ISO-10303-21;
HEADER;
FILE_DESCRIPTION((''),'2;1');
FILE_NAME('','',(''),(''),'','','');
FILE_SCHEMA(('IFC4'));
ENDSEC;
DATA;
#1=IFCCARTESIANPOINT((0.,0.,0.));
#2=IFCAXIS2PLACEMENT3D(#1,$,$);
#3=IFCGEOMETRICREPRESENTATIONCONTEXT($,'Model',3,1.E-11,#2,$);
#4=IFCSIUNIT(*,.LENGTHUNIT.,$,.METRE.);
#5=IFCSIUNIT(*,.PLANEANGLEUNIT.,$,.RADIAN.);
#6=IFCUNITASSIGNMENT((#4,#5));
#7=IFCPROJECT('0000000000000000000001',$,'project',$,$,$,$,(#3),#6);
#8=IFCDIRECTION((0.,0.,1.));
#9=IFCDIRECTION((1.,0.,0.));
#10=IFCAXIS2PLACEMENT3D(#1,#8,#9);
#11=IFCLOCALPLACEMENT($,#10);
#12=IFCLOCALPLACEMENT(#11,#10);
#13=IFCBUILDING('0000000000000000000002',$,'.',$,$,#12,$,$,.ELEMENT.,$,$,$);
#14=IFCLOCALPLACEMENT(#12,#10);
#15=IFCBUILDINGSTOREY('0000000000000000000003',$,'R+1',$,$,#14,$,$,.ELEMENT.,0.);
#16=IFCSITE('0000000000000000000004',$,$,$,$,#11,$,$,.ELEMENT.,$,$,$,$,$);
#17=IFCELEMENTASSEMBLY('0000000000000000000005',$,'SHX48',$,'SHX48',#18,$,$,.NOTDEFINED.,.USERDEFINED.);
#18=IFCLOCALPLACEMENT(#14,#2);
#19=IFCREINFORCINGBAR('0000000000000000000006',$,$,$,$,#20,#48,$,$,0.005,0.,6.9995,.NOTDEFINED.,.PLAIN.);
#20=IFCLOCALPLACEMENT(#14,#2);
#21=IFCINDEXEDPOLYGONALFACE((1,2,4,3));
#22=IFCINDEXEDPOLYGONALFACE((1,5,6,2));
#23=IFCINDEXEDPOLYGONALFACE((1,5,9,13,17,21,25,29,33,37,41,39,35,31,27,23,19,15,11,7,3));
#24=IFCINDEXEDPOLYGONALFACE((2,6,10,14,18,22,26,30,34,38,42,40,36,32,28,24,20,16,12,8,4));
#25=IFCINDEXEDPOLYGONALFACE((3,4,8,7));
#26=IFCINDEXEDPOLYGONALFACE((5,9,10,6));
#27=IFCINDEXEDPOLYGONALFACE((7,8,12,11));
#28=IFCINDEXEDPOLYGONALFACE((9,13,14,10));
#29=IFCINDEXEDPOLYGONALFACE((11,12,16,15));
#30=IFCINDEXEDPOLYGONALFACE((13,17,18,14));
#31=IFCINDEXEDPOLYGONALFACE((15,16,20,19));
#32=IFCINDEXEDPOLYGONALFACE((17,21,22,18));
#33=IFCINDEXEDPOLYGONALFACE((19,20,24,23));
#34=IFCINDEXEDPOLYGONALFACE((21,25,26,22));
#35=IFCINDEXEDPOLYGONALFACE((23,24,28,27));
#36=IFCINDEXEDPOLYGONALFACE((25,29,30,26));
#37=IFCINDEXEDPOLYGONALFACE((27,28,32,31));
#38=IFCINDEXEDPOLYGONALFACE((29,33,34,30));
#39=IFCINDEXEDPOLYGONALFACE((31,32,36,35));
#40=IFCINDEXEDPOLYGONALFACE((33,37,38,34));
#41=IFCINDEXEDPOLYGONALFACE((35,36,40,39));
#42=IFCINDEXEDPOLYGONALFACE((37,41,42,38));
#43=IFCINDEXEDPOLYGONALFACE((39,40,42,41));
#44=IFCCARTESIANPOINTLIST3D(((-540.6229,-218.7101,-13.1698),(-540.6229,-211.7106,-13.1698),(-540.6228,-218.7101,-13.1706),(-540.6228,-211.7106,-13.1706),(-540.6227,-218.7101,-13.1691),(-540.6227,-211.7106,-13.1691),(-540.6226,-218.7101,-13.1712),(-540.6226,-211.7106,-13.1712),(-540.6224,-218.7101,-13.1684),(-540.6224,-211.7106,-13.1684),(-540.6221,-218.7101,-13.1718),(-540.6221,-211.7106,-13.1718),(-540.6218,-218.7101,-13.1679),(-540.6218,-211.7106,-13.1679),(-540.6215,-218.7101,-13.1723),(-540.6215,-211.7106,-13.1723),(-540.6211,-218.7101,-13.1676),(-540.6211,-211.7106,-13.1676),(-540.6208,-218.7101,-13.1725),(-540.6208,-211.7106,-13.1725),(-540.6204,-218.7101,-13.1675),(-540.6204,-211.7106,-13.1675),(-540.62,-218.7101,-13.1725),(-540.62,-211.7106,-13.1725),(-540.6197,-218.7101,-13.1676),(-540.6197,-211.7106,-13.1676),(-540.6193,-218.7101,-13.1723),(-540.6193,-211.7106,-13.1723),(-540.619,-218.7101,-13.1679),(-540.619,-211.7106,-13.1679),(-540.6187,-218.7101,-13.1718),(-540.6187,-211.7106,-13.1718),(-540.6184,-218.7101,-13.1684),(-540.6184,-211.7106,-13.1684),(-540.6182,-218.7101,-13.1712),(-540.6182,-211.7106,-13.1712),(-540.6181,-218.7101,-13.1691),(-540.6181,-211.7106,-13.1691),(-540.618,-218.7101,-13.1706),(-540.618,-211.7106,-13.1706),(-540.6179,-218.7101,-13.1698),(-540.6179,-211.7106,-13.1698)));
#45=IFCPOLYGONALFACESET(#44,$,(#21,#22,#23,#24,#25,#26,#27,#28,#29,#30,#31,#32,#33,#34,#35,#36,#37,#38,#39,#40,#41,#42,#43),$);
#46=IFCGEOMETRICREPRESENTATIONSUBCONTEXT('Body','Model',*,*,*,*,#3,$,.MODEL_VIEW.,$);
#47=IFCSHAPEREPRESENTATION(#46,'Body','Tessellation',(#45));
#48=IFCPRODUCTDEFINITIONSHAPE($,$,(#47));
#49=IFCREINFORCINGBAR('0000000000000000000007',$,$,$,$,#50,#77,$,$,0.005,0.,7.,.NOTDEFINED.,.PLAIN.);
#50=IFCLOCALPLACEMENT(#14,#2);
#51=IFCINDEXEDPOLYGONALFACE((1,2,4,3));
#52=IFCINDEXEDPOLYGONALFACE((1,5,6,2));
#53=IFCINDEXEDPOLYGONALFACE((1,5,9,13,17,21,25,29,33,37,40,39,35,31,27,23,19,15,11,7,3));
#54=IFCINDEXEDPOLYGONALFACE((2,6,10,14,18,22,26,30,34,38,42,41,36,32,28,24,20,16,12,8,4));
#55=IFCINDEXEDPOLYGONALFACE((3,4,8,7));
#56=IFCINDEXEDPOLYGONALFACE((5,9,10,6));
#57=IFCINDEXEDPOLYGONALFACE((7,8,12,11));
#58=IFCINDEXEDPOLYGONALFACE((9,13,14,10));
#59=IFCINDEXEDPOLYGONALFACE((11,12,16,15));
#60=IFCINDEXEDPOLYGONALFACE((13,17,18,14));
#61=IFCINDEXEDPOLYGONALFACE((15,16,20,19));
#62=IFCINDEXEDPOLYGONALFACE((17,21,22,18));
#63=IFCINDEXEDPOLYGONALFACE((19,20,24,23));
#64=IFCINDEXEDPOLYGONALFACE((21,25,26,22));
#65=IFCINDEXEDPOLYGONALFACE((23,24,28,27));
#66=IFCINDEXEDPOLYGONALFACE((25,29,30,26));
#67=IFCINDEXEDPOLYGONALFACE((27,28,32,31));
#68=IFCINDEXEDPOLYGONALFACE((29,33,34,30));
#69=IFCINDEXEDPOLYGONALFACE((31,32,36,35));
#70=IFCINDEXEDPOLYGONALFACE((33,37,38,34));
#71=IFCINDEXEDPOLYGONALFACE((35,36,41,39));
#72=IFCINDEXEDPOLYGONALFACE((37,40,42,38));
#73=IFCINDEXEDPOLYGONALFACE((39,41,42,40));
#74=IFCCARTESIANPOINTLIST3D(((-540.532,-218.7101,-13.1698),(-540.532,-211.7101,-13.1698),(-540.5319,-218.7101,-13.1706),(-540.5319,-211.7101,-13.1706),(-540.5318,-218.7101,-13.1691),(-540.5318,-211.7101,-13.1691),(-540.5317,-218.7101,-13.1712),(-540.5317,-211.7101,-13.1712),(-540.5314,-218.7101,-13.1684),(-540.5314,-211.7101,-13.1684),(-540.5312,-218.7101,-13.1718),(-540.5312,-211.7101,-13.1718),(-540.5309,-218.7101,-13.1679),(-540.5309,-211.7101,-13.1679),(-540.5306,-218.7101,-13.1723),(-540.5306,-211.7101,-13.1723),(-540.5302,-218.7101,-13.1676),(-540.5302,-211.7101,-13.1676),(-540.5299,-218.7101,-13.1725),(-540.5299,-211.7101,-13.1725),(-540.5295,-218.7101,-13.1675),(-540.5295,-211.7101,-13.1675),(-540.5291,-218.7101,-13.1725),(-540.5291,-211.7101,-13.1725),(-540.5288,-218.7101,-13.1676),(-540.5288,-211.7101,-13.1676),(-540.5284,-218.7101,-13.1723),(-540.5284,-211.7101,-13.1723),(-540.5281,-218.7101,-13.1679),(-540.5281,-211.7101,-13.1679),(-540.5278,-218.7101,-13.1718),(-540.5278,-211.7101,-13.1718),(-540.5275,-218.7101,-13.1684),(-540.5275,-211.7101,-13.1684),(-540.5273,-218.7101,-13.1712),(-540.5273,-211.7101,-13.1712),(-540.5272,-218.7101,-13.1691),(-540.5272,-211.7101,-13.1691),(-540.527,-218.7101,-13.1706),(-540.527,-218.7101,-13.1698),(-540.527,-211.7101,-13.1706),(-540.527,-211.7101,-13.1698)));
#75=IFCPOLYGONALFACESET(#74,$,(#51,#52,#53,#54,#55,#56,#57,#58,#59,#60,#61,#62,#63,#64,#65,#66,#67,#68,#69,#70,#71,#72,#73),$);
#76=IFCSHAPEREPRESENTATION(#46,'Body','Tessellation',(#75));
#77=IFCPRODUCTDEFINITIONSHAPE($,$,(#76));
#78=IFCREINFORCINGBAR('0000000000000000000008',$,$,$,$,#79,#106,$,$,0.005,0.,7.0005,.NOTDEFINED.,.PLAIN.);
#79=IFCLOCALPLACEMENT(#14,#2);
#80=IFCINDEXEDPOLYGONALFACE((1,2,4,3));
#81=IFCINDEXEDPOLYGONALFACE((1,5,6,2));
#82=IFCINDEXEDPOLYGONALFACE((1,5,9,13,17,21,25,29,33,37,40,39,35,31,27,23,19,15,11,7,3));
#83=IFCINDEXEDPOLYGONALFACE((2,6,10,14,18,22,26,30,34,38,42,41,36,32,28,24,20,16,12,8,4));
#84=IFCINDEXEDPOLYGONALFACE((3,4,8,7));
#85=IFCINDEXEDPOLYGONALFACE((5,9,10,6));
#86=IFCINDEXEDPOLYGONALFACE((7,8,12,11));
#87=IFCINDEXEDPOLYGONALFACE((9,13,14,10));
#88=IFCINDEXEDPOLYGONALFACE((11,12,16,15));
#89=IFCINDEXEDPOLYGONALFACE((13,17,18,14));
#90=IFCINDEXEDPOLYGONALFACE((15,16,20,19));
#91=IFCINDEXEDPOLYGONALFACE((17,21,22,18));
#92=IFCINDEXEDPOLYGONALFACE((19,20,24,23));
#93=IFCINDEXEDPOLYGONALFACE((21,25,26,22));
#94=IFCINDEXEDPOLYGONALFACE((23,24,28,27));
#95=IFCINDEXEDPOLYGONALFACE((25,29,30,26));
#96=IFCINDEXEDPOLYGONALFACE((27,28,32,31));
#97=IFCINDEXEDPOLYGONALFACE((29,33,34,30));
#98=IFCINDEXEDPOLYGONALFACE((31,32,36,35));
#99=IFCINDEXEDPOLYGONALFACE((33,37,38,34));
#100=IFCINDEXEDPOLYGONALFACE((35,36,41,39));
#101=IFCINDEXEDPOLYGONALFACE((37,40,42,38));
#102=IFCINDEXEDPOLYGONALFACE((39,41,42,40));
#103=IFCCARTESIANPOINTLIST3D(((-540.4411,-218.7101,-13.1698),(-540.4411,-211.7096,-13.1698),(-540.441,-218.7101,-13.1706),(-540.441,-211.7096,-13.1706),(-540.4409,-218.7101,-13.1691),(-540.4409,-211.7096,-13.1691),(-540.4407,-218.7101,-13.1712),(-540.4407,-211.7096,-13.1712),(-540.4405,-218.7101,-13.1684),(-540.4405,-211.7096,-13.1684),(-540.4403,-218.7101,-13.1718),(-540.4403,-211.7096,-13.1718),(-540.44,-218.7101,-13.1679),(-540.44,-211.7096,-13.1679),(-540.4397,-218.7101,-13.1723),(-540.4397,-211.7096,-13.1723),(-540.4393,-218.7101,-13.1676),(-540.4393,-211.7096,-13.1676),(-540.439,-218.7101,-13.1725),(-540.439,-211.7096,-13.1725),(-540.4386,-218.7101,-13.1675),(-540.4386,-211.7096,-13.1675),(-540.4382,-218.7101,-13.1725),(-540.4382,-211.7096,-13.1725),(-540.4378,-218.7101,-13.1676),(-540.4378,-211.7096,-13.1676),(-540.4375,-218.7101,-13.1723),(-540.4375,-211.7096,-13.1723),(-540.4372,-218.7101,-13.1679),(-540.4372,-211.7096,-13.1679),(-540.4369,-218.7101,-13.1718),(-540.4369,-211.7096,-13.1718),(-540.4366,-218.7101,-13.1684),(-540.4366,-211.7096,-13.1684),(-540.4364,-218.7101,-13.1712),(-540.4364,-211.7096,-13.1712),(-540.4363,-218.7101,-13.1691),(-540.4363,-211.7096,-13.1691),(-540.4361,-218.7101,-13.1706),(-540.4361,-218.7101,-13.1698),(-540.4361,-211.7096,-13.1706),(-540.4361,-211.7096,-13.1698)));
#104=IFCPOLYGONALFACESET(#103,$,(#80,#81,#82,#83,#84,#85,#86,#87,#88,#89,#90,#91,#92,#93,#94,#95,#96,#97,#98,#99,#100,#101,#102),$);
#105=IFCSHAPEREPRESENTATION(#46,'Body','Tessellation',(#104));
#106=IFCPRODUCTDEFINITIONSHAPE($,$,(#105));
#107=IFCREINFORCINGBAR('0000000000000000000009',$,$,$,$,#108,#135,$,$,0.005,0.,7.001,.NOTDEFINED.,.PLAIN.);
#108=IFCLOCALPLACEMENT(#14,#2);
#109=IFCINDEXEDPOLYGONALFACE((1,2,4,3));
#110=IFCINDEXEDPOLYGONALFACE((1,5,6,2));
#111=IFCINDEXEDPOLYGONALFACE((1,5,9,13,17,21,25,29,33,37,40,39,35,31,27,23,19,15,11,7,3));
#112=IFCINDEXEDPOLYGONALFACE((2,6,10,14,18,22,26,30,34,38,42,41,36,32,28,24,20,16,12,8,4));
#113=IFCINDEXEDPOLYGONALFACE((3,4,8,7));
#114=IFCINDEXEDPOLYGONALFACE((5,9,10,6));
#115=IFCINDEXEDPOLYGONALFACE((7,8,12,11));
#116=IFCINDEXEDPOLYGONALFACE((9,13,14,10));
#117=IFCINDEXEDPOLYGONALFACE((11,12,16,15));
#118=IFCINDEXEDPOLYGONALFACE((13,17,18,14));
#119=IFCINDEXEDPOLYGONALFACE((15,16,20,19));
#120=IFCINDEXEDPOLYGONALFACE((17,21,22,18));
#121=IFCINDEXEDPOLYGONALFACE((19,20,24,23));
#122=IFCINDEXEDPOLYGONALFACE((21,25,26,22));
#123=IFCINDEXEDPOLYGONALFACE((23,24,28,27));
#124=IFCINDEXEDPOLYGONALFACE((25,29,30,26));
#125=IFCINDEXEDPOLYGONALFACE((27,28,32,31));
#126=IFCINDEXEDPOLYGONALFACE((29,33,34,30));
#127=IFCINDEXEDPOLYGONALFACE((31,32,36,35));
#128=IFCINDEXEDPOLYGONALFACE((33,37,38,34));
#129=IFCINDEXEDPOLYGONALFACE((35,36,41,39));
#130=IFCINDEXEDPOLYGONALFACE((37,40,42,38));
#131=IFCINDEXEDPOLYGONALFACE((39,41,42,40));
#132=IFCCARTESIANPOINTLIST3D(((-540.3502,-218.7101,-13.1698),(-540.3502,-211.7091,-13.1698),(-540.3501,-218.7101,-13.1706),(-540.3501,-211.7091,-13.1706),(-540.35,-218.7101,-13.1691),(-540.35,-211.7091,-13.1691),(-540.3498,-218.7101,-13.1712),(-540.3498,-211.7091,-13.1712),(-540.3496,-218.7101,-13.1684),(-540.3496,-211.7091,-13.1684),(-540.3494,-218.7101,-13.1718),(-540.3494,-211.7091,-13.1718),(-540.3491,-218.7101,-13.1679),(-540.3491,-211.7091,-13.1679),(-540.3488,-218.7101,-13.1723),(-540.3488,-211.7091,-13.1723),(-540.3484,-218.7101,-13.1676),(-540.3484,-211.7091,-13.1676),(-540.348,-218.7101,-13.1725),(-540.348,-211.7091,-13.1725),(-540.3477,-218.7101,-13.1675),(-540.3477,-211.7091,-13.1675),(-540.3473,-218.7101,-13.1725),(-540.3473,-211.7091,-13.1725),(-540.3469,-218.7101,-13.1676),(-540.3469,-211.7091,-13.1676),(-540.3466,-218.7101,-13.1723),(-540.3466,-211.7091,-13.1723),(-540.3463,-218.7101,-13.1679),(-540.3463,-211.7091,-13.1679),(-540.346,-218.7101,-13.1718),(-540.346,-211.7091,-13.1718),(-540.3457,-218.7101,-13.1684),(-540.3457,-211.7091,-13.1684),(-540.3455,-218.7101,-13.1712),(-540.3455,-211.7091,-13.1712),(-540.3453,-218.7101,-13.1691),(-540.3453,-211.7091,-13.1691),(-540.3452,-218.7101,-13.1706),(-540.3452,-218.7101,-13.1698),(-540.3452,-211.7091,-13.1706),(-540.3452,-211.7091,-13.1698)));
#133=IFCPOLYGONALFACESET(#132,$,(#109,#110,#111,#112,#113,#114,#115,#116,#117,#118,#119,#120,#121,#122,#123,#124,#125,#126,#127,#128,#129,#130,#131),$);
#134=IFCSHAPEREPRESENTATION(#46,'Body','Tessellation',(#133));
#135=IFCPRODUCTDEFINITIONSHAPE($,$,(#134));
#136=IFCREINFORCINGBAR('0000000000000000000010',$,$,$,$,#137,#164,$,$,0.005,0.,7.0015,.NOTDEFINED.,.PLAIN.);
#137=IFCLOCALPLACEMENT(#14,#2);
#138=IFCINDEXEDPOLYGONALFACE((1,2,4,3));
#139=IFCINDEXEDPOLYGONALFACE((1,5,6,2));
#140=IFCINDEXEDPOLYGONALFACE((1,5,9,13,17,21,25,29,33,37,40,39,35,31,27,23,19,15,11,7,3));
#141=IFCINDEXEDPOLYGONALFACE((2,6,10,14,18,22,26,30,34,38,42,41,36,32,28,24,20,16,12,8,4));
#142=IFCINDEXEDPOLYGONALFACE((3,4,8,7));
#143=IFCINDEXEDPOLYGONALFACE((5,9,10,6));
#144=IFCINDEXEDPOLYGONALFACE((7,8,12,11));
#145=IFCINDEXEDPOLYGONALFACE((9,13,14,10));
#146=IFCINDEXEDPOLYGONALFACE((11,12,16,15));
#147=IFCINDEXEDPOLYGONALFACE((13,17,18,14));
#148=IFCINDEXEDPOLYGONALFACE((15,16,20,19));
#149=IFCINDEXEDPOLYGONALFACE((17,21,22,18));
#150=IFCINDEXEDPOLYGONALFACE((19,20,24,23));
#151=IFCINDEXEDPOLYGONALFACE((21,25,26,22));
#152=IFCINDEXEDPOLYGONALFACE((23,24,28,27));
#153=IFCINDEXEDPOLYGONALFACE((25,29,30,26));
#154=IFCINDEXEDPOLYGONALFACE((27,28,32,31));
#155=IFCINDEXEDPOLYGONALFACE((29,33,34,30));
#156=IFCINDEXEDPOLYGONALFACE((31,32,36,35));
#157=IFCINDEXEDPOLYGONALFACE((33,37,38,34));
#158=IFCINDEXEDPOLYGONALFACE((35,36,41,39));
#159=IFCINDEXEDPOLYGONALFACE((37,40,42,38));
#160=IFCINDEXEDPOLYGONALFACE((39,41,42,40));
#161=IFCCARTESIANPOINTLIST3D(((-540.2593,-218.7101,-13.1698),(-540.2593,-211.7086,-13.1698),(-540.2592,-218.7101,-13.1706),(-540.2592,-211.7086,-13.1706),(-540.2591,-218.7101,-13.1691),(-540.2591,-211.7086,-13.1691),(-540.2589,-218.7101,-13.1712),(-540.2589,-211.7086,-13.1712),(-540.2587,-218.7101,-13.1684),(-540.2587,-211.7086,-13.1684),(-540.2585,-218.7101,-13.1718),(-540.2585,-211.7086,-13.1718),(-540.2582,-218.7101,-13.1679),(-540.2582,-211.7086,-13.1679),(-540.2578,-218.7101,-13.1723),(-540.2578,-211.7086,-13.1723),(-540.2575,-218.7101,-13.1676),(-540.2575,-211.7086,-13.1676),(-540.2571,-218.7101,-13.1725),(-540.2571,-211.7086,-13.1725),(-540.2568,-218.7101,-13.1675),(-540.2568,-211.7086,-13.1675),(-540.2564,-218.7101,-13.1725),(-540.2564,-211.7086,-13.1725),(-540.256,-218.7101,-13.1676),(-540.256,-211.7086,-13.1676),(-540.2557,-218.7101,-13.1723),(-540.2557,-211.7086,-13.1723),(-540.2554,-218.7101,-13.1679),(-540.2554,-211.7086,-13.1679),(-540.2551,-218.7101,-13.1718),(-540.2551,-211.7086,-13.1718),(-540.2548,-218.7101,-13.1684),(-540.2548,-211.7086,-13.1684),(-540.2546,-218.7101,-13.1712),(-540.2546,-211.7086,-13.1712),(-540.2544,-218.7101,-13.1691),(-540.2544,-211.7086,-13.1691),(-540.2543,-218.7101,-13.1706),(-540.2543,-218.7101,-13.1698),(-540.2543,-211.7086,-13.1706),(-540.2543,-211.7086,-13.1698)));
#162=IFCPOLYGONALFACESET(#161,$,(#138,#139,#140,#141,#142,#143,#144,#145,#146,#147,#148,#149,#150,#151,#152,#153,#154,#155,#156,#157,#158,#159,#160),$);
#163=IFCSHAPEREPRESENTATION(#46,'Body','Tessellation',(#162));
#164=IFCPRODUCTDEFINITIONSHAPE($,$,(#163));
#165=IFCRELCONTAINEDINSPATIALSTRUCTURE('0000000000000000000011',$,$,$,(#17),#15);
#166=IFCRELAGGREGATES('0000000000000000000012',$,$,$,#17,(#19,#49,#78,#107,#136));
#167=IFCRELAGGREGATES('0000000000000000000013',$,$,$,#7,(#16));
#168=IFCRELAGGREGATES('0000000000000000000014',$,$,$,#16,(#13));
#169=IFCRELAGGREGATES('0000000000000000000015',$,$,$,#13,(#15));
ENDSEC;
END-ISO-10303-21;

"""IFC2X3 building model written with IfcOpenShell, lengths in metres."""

from ifc_helpers import new_model, entity, si_unit, origin, origin_with_axes, place, context, subcontext, project, spatial, shape, element, aggregate, save


model = new_model("IFC2X3")

# Units and contexts
model_context = context("Model", 3, precision=1e-11, world=origin())
body_context = subcontext(model_context, "Body", "Model", "MODEL_VIEW")
ifc_project = project(units=[si_unit("LENGTHUNIT", "METRE"), si_unit("PLANEANGLEUNIT", "RADIAN")], contexts=[model_context])

# Site, building, storey
site_placement = place(None, origin_with_axes())
site = spatial("IfcSite", under=ifc_project, at=site_placement, CompositionType="ELEMENT")
building_placement = place(site_placement, origin_with_axes())
building = spatial("IfcBuilding", under=site, at=building_placement, Name=".", CompositionType="ELEMENT")
storey_placement = place(building_placement, origin_with_axes())
storey = spatial("IfcBuildingStorey", under=building, at=storey_placement, Name="R+1", CompositionType="ELEMENT", Elevation=0.0)

# Element assembly, reinforcing bars
assembly_1_placement = place(storey_placement, origin_with_axes())
assembly_1 = element("IfcElementAssembly", 1, at=assembly_1_placement, inside=storey, Name="SHX48", ObjectType="SHX48", AssemblyPlace="NOTDEFINED", PredefinedType="USERDEFINED")
reinforcing_bar_1_placement = place(assembly_1_placement, origin_with_axes())
reinforcing_bar_1 = element("IfcReinforcingBar", 2, at=reinforcing_bar_1_placement, BarLength=6.9995, BarRole="NOTDEFINED", BarSurface="PLAIN", CrossSectionArea=0.0, NominalDiameter=0.005, shapes=[
    shape(body_context, "Body", "AdvancedSweptSolid", [entity("IfcSweptDiskSolid", entity("IfcPolyline", [entity("IfcCartesianPoint", [540.6204, 211.7106, 13.17]), entity("IfcCartesianPoint", [540.6204, 218.7101, 13.17])]), 0.0025, None, 0.0, 6.9995)]),
    shape(body_context, "Body", "AdvancedSweptSolid", [entity("IfcSweptDiskSolid", entity("IfcPolyline", [entity("IfcCartesianPoint", [540.6204, 211.7106, 13.17]), entity("IfcCartesianPoint", [540.6204, 218.7101, 13.17])]), 0.0025, None, 0.0, 6.9995)]),
])
reinforcing_bar_2_placement = place(assembly_1_placement, origin_with_axes())
reinforcing_bar_2 = element("IfcReinforcingBar", 3, at=reinforcing_bar_2_placement, BarLength=7.0, BarRole="NOTDEFINED", BarSurface="PLAIN", CrossSectionArea=0.0, NominalDiameter=0.005, shapes=[
    shape(body_context, "Body", "AdvancedSweptSolid", [entity("IfcSweptDiskSolid", entity("IfcPolyline", [entity("IfcCartesianPoint", [540.5295, 211.7101, 13.17]), entity("IfcCartesianPoint", [540.5295, 218.7101, 13.17])]), 0.0025, None, 0.0, 7.0)]),
    shape(body_context, "Body", "AdvancedSweptSolid", [entity("IfcSweptDiskSolid", entity("IfcPolyline", [entity("IfcCartesianPoint", [540.5295, 211.7101, 13.17]), entity("IfcCartesianPoint", [540.5295, 218.7101, 13.17])]), 0.0025, None, 0.0, 7.0)]),
])
reinforcing_bar_3_placement = place(assembly_1_placement, origin_with_axes())
reinforcing_bar_3 = element("IfcReinforcingBar", 4, at=reinforcing_bar_3_placement, BarLength=7.0005, BarRole="NOTDEFINED", BarSurface="PLAIN", CrossSectionArea=0.0, NominalDiameter=0.005, shapes=[
    shape(body_context, "Body", "AdvancedSweptSolid", [entity("IfcSweptDiskSolid", entity("IfcPolyline", [entity("IfcCartesianPoint", [540.4386, 211.7096, 13.17]), entity("IfcCartesianPoint", [540.4386, 218.7101, 13.17])]), 0.0025, None, 0.0, 7.0005)]),
    shape(body_context, "Body", "AdvancedSweptSolid", [entity("IfcSweptDiskSolid", entity("IfcPolyline", [entity("IfcCartesianPoint", [540.4386, 211.7096, 13.17]), entity("IfcCartesianPoint", [540.4386, 218.7101, 13.17])]), 0.0025, None, 0.0, 7.0005)]),
])
reinforcing_bar_4_placement = place(assembly_1_placement, origin_with_axes())
reinforcing_bar_4 = element("IfcReinforcingBar", 5, at=reinforcing_bar_4_placement, BarLength=7.001, BarRole="NOTDEFINED", BarSurface="PLAIN", CrossSectionArea=0.0, NominalDiameter=0.005, shapes=[
    shape(body_context, "Body", "AdvancedSweptSolid", [entity("IfcSweptDiskSolid", entity("IfcPolyline", [entity("IfcCartesianPoint", [540.3477, 211.7091, 13.17]), entity("IfcCartesianPoint", [540.3477, 218.7101, 13.17])]), 0.0025, None, 0.0, 7.001)]),
    shape(body_context, "Body", "AdvancedSweptSolid", [entity("IfcSweptDiskSolid", entity("IfcPolyline", [entity("IfcCartesianPoint", [540.3477, 211.7091, 13.17]), entity("IfcCartesianPoint", [540.3477, 218.7101, 13.17])]), 0.0025, None, 0.0, 7.001)]),
])
reinforcing_bar_5_placement = place(assembly_1_placement, origin_with_axes())
reinforcing_bar_5 = element("IfcReinforcingBar", 6, at=reinforcing_bar_5_placement, BarLength=7.0015, BarRole="NOTDEFINED", BarSurface="PLAIN", CrossSectionArea=0.0, NominalDiameter=0.005, shapes=[
    shape(body_context, "Body", "AdvancedSweptSolid", [entity("IfcSweptDiskSolid", entity("IfcPolyline", [entity("IfcCartesianPoint", [540.2568, 211.7086, 13.17]), entity("IfcCartesianPoint", [540.2568, 218.7101, 13.17])]), 0.0025, None, 0.0, 7.0015)]),
    shape(body_context, "Body", "AdvancedSweptSolid", [entity("IfcSweptDiskSolid", entity("IfcPolyline", [entity("IfcCartesianPoint", [540.2568, 211.7086, 13.17]), entity("IfcCartesianPoint", [540.2568, 218.7101, 13.17])]), 0.0025, None, 0.0, 7.0015)]),
])
aggregate(assembly_1, [reinforcing_bar_1, reinforcing_bar_2, reinforcing_bar_3, reinforcing_bar_4, reinforcing_bar_5])

save(model, "model.ifc")
